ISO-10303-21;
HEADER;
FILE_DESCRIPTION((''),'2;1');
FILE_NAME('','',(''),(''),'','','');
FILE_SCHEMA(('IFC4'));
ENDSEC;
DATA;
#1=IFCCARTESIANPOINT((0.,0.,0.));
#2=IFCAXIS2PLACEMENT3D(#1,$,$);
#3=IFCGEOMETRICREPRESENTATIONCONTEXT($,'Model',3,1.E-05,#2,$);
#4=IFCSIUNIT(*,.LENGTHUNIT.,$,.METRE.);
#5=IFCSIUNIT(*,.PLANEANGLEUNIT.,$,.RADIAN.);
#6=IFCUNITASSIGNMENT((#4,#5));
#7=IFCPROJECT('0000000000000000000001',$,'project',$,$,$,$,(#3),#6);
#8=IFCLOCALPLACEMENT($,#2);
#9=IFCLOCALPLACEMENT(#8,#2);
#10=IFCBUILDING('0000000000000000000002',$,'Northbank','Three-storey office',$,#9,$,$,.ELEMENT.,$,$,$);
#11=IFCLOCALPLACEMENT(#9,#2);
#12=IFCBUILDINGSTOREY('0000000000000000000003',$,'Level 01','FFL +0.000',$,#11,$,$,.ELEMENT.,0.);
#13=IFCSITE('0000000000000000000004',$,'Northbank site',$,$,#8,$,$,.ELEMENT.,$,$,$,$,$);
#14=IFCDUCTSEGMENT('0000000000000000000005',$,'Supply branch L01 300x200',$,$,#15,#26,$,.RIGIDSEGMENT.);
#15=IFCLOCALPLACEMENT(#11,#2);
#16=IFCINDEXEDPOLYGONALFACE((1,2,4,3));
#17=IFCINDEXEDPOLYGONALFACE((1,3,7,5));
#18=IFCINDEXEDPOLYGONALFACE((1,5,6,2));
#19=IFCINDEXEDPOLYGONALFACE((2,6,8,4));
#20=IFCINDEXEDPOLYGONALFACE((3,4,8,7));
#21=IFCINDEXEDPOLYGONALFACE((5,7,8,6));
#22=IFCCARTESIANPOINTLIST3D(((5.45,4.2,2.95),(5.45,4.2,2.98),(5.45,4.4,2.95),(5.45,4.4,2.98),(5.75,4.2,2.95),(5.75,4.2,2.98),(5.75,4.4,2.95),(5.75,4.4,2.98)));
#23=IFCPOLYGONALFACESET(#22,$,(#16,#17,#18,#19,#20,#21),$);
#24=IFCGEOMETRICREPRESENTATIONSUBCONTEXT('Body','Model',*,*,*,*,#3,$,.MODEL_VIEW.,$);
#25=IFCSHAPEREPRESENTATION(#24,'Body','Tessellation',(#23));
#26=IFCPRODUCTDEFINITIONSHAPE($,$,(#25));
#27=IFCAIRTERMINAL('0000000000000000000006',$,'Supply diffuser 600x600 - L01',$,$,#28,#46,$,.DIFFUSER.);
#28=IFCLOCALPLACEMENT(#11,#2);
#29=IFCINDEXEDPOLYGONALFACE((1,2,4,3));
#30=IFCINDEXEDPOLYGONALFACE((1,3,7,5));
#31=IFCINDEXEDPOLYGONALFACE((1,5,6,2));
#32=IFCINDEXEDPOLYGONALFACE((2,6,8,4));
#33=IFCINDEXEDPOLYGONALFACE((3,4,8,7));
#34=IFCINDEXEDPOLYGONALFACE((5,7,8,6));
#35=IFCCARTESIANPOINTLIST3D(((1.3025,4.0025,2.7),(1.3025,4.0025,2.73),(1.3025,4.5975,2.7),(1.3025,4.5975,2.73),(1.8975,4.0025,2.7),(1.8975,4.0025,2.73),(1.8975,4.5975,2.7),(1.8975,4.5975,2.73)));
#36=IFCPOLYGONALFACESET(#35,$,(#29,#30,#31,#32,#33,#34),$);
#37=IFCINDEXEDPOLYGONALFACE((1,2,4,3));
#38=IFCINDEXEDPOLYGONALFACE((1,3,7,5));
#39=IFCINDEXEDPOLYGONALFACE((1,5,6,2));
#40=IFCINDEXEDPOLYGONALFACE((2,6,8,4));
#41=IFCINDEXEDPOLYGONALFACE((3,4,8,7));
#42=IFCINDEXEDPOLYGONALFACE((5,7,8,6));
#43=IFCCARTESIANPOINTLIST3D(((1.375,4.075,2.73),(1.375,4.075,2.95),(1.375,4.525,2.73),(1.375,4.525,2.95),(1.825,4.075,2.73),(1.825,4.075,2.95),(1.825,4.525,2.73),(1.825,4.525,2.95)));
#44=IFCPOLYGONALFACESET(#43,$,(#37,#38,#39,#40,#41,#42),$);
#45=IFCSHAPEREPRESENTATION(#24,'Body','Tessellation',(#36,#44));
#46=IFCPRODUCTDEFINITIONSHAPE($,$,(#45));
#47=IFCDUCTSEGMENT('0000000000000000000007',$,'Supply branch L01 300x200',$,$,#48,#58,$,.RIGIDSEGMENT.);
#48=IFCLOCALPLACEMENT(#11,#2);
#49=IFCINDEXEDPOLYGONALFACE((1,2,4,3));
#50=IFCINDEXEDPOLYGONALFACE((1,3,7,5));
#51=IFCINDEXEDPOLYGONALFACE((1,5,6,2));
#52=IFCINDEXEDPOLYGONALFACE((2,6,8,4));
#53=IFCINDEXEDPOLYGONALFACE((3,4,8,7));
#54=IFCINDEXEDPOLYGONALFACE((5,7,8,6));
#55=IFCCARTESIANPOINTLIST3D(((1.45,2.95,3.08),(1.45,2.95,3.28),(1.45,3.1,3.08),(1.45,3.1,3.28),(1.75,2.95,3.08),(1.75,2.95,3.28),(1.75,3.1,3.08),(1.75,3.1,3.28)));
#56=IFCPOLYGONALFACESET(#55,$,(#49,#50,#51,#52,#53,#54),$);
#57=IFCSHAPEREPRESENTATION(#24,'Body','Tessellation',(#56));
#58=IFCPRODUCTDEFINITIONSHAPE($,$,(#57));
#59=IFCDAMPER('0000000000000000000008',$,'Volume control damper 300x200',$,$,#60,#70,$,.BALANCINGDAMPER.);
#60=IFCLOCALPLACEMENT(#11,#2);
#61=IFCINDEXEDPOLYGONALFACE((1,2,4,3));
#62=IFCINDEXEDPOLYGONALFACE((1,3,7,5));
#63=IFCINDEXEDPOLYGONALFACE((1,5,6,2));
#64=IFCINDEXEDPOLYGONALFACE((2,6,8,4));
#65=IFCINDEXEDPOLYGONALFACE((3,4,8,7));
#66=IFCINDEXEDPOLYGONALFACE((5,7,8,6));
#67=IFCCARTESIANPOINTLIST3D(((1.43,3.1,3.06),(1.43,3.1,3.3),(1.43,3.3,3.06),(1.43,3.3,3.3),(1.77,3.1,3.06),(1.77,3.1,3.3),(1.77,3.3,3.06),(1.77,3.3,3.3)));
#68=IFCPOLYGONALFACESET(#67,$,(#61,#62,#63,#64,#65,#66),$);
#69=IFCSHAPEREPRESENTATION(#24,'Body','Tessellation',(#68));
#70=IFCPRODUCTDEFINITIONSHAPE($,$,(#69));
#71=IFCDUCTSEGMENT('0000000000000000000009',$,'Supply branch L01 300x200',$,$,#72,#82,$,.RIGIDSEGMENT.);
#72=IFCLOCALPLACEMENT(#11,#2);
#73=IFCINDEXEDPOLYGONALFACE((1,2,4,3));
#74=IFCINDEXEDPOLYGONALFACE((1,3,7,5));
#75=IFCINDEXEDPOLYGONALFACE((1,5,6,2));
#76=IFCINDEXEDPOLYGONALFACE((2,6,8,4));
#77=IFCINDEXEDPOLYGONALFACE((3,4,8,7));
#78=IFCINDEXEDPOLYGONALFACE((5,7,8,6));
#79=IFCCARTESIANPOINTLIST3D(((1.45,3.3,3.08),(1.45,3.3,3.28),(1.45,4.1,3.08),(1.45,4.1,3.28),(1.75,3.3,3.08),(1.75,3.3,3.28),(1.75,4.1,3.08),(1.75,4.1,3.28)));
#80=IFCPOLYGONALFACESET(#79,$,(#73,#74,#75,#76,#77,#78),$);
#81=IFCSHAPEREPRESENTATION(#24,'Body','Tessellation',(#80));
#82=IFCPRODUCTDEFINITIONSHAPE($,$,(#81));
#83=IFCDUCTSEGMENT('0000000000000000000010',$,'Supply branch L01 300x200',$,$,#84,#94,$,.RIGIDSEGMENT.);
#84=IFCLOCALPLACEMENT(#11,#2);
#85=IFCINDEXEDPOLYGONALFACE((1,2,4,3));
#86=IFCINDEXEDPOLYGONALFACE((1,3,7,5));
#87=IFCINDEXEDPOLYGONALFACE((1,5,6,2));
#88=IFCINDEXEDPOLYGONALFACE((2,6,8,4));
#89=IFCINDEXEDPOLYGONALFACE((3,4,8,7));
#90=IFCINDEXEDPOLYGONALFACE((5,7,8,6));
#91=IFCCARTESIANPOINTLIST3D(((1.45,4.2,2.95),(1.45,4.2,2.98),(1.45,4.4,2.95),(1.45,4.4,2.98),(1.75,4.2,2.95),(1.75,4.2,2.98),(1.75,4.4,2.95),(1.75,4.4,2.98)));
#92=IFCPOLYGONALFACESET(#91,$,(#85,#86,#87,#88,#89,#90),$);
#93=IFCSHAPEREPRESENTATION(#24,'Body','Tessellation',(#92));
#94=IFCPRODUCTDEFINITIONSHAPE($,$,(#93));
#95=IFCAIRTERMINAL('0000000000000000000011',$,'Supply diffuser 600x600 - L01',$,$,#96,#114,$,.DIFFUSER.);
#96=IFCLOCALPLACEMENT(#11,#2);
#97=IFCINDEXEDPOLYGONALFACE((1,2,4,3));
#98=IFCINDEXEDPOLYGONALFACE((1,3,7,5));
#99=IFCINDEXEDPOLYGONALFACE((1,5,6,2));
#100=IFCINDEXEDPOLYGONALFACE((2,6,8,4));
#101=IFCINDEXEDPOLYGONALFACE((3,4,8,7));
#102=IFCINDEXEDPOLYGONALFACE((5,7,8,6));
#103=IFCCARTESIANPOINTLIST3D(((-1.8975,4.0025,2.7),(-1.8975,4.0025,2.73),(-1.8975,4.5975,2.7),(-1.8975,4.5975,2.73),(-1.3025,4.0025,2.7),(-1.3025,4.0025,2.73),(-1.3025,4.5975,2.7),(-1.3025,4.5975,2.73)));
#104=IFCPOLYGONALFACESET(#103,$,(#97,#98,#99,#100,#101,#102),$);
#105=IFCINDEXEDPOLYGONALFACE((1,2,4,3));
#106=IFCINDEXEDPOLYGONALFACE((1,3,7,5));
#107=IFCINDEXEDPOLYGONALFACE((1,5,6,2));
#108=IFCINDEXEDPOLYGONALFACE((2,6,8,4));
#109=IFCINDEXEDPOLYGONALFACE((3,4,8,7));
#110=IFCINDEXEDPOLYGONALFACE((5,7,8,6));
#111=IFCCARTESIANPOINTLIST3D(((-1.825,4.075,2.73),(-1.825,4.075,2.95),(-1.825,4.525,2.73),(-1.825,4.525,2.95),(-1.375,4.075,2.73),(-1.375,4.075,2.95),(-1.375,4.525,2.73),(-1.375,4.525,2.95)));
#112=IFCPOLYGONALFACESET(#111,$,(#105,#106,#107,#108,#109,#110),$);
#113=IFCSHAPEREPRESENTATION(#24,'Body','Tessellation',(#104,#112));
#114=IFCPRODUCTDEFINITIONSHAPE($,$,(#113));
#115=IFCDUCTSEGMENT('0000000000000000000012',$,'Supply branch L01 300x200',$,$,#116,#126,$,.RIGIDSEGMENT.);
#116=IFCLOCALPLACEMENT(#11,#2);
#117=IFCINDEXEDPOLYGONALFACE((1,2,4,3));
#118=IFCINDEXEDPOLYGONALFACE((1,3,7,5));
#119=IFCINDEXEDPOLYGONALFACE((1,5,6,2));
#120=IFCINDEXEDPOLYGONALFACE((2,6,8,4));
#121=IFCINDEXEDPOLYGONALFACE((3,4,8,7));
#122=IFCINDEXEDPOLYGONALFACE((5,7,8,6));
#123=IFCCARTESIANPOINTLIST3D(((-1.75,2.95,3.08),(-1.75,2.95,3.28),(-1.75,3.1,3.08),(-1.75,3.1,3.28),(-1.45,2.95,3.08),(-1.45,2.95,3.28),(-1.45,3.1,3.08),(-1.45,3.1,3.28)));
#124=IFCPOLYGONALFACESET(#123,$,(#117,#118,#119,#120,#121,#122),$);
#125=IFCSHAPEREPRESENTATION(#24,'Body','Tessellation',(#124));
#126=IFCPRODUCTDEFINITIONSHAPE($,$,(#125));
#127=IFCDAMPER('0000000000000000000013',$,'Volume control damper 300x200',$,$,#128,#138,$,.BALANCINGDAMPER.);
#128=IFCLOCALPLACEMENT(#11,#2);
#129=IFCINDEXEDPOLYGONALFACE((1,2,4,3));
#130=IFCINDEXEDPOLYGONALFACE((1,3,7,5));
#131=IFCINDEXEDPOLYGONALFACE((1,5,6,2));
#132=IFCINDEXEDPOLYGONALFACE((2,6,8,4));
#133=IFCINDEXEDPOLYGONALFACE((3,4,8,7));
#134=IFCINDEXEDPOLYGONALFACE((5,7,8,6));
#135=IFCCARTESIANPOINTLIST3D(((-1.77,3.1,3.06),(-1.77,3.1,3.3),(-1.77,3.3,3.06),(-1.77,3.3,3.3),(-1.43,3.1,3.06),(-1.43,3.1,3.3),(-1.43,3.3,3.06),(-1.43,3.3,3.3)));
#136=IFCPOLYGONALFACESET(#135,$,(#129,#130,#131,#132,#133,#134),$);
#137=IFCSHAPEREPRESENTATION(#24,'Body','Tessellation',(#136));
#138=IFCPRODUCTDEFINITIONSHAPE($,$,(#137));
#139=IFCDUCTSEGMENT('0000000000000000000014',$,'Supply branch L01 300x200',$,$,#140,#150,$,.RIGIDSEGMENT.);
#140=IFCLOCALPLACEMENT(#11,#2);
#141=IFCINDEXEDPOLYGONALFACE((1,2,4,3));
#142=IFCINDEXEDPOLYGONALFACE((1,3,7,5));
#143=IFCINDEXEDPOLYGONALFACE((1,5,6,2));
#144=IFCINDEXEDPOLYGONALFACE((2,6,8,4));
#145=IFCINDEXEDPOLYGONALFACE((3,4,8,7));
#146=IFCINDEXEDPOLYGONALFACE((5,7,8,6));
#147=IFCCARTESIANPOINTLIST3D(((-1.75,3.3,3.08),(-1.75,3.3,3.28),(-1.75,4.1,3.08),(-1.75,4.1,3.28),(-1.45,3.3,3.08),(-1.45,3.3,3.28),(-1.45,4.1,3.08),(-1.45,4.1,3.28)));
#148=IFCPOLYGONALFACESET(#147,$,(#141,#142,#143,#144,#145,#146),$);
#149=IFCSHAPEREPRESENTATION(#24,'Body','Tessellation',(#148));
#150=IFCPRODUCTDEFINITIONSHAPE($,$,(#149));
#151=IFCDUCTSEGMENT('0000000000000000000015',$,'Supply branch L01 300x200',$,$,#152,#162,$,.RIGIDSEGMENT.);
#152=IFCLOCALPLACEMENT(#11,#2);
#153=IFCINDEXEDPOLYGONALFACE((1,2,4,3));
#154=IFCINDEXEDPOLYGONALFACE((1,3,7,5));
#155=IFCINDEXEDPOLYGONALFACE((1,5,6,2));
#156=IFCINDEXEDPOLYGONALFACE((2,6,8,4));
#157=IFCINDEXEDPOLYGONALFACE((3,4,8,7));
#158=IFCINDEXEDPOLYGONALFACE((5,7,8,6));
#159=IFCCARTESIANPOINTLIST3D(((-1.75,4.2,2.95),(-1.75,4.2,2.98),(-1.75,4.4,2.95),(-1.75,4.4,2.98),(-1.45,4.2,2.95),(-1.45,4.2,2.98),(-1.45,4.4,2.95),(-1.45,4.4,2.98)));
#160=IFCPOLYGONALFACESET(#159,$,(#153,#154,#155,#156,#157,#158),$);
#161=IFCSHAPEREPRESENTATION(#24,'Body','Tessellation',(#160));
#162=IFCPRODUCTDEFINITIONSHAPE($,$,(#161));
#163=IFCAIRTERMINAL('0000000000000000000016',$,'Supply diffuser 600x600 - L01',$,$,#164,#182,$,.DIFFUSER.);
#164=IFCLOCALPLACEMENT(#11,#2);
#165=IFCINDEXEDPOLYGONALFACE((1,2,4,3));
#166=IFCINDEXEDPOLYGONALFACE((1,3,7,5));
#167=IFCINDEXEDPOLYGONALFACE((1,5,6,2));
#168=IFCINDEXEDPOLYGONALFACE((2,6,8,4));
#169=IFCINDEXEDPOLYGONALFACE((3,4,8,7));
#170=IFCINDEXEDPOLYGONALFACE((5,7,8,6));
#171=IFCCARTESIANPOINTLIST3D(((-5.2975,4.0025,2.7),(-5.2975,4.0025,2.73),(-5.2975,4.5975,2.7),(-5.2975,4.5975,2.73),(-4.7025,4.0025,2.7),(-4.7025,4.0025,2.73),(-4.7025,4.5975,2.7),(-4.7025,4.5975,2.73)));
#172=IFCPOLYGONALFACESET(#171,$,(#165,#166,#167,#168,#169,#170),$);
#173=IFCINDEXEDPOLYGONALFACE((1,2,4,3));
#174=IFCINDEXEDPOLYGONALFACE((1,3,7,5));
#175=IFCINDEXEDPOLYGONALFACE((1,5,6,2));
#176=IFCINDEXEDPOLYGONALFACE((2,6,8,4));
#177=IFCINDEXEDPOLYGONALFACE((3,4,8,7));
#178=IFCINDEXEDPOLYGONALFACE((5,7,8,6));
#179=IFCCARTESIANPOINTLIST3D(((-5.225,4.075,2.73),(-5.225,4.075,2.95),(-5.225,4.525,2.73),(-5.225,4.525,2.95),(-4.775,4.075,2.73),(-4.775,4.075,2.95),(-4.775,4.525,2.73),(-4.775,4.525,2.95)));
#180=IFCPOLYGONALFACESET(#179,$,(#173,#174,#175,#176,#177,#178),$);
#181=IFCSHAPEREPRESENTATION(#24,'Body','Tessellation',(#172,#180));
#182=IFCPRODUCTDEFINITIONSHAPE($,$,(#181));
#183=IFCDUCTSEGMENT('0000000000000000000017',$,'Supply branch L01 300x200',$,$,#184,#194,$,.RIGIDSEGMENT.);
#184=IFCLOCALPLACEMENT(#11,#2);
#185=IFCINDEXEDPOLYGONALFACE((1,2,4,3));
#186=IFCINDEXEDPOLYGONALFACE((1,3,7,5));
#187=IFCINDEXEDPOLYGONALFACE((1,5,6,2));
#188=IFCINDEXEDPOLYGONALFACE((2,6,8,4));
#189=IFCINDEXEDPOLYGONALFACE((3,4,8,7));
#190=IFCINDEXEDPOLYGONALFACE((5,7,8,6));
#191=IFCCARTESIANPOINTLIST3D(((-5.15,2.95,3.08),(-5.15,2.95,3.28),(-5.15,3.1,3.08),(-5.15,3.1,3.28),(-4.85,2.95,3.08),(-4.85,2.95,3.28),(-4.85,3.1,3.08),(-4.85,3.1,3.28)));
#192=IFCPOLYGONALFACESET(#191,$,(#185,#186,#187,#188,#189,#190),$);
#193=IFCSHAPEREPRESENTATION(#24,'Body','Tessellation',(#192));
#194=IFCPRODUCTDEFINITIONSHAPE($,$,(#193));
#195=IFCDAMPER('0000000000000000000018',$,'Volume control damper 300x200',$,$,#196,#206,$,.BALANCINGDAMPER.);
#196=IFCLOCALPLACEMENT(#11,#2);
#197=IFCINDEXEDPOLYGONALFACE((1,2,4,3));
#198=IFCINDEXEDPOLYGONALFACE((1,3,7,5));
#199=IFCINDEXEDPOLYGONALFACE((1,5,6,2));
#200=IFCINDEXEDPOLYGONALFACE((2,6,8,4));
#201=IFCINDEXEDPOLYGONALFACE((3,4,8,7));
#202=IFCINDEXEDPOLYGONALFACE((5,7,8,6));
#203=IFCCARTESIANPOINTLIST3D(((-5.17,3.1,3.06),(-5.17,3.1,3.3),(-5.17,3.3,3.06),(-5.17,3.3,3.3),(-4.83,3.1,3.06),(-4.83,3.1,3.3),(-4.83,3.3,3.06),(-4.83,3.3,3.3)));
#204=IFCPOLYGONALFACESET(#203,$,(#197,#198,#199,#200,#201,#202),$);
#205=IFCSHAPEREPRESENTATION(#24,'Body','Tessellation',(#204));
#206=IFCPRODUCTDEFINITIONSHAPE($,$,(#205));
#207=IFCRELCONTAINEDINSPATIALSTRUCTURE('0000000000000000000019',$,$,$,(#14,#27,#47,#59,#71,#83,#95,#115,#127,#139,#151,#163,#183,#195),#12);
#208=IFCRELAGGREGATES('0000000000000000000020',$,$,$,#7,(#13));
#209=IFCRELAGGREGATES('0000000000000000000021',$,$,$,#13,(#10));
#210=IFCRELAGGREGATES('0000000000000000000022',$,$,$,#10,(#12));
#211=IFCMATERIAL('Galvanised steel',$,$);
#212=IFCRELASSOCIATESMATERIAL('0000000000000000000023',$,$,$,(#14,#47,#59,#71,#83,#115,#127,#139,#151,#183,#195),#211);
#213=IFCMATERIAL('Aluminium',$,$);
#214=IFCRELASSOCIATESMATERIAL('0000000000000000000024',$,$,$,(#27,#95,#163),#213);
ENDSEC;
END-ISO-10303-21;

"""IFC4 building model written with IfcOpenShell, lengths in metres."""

from ifc_helpers import new_model, si_unit, frame, origin, place, context, subcontext, project, spatial, rectangle, extrude, material, element, save


model = new_model("IFC4")

# Units and contexts
model_context = context("Model", 3, precision=1e-05, world=origin())
body_context = subcontext(model_context, "Body", "Model", "MODEL_VIEW")
ifc_project = project(units=[si_unit("LENGTHUNIT", "METRE"), si_unit("PLANEANGLEUNIT", "RADIAN")], contexts=[model_context])

# Site, building, storey
site_placement = place(None, origin())
site = spatial("IfcSite", under=ifc_project, at=site_placement, Name="Northbank site", CompositionType="ELEMENT")
building_placement = place(site_placement, origin())
building = spatial("IfcBuilding", under=site, at=building_placement, Name="Northbank", Description="Three-storey office", CompositionType="ELEMENT")
storey_placement = place(building_placement, origin())
storey = spatial("IfcBuildingStorey", under=building, at=storey_placement, Name="Level 01", Description="FFL +0.000", CompositionType="ELEMENT", Elevation=0.0)

# Duct segment
ifc_material_1 = material(Name="Galvanised steel")
duct_segment_1_placement = place(storey_placement, origin())
element("IfcDuctSegment", 1, at=duct_segment_1_placement, inside=storey, material=ifc_material_1, Name="Supply branch L01 300x200", PredefinedType="RIGIDSEGMENT", context=body_context, shape_type="SweptSolid", body=[
    extrude(rectangle(XDim=0.3, YDim=0.2), frame((5.6, 4.3, 2.98), z_axis=(0.0, 0.0, -1.0), x_axis=(-1.0, 0.0, 0.0)), (0.0, 0.0, 1.0), 0.03),
])

# Air terminal
ifc_material_2 = material(Name="Aluminium")
air_terminal_1_placement = place(storey_placement, origin())
element("IfcAirTerminal", 2, at=air_terminal_1_placement, inside=storey, material=ifc_material_2, Name="Supply diffuser 600x600 - L01", PredefinedType="DIFFUSER", context=body_context, shape_type="SweptSolid", body=[
    extrude(rectangle(XDim=0.595, YDim=0.595), frame((1.6, 4.3, 2.7)), (0.0, 0.0, 1.0), 0.03),
    extrude(rectangle(XDim=0.45, YDim=0.45), frame((1.6, 4.3, 2.73)), (0.0, 0.0, 1.0), 0.22),
])

# Duct segment
duct_segment_2_placement = place(storey_placement, origin())
element("IfcDuctSegment", 3, at=duct_segment_2_placement, inside=storey, material=ifc_material_1, Name="Supply branch L01 300x200", PredefinedType="RIGIDSEGMENT", context=body_context, shape_type="SweptSolid", body=[
    extrude(rectangle(XDim=0.3, YDim=0.2), frame((1.6, 2.95, 3.18), z_axis=(0.0, 1.0, 0.0), x_axis=(-1.0, 0.0, 0.0)), (0.0, 0.0, 1.0), 0.15),
])

# Damper
damper_1_placement = place(storey_placement, origin())
element("IfcDamper", 4, at=damper_1_placement, inside=storey, material=ifc_material_1, Name="Volume control damper 300x200", PredefinedType="BALANCINGDAMPER", context=body_context, shape_type="SweptSolid", body=[
    extrude(rectangle(XDim=0.34, YDim=0.24), frame((1.6, 3.1, 3.18), z_axis=(0.0, 1.0, 0.0), x_axis=(-1.0, 0.0, 0.0)), (0.0, 0.0, 1.0), 0.2),
])

# Duct segments
duct_segment_3_placement = place(storey_placement, origin())
element("IfcDuctSegment", 5, at=duct_segment_3_placement, inside=storey, material=ifc_material_1, Name="Supply branch L01 300x200", PredefinedType="RIGIDSEGMENT", context=body_context, shape_type="SweptSolid", body=[
    extrude(rectangle(XDim=0.3, YDim=0.2), frame((1.6, 3.3, 3.18), z_axis=(0.0, 1.0, 0.0), x_axis=(-1.0, 0.0, 0.0)), (0.0, 0.0, 1.0), 0.8),
])
duct_segment_4_placement = place(storey_placement, origin())
element("IfcDuctSegment", 6, at=duct_segment_4_placement, inside=storey, material=ifc_material_1, Name="Supply branch L01 300x200", PredefinedType="RIGIDSEGMENT", context=body_context, shape_type="SweptSolid", body=[
    extrude(rectangle(XDim=0.3, YDim=0.2), frame((1.6, 4.3, 2.98), z_axis=(0.0, 0.0, -1.0), x_axis=(-1.0, 0.0, 0.0)), (0.0, 0.0, 1.0), 0.03),
])

# Air terminal
air_terminal_2_placement = place(storey_placement, origin())
element("IfcAirTerminal", 7, at=air_terminal_2_placement, inside=storey, material=ifc_material_2, Name="Supply diffuser 600x600 - L01", PredefinedType="DIFFUSER", context=body_context, shape_type="SweptSolid", body=[
    extrude(rectangle(XDim=0.595, YDim=0.595), frame((-1.6, 4.3, 2.7)), (0.0, 0.0, 1.0), 0.03),
    extrude(rectangle(XDim=0.45, YDim=0.45), frame((-1.6, 4.3, 2.73)), (0.0, 0.0, 1.0), 0.22),
])

# Duct segment
duct_segment_5_placement = place(storey_placement, origin())
element("IfcDuctSegment", 8, at=duct_segment_5_placement, inside=storey, material=ifc_material_1, Name="Supply branch L01 300x200", PredefinedType="RIGIDSEGMENT", context=body_context, shape_type="SweptSolid", body=[
    extrude(rectangle(XDim=0.3, YDim=0.2), frame((-1.6, 2.95, 3.18), z_axis=(0.0, 1.0, 0.0), x_axis=(-1.0, 0.0, 0.0)), (0.0, 0.0, 1.0), 0.15),
])

# Damper
damper_2_placement = place(storey_placement, origin())
element("IfcDamper", 9, at=damper_2_placement, inside=storey, material=ifc_material_1, Name="Volume control damper 300x200", PredefinedType="BALANCINGDAMPER", context=body_context, shape_type="SweptSolid", body=[
    extrude(rectangle(XDim=0.34, YDim=0.24), frame((-1.6, 3.1, 3.18), z_axis=(0.0, 1.0, 0.0), x_axis=(-1.0, 0.0, 0.0)), (0.0, 0.0, 1.0), 0.2),
])

# Duct segments
duct_segment_6_placement = place(storey_placement, origin())
element("IfcDuctSegment", 10, at=duct_segment_6_placement, inside=storey, material=ifc_material_1, Name="Supply branch L01 300x200", PredefinedType="RIGIDSEGMENT", context=body_context, shape_type="SweptSolid", body=[
    extrude(rectangle(XDim=0.3, YDim=0.2), frame((-1.6, 3.3, 3.18), z_axis=(0.0, 1.0, 0.0), x_axis=(-1.0, 0.0, 0.0)), (0.0, 0.0, 1.0), 0.8),
])
duct_segment_7_placement = place(storey_placement, origin())
element("IfcDuctSegment", 11, at=duct_segment_7_placement, inside=storey, material=ifc_material_1, Name="Supply branch L01 300x200", PredefinedType="RIGIDSEGMENT", context=body_context, shape_type="SweptSolid", body=[
    extrude(rectangle(XDim=0.3, YDim=0.2), frame((-1.6, 4.3, 2.98), z_axis=(0.0, 0.0, -1.0), x_axis=(-1.0, 0.0, 0.0)), (0.0, 0.0, 1.0), 0.03),
])

# Air terminal
air_terminal_3_placement = place(storey_placement, origin())
element("IfcAirTerminal", 12, at=air_terminal_3_placement, inside=storey, material=ifc_material_2, Name="Supply diffuser 600x600 - L01", PredefinedType="DIFFUSER", context=body_context, shape_type="SweptSolid", body=[
    extrude(rectangle(XDim=0.595, YDim=0.595), frame((-5.0, 4.3, 2.7)), (0.0, 0.0, 1.0), 0.03),
    extrude(rectangle(XDim=0.45, YDim=0.45), frame((-5.0, 4.3, 2.73)), (0.0, 0.0, 1.0), 0.22),
])

# Duct segment
duct_segment_8_placement = place(storey_placement, origin())
element("IfcDuctSegment", 13, at=duct_segment_8_placement, inside=storey, material=ifc_material_1, Name="Supply branch L01 300x200", PredefinedType="RIGIDSEGMENT", context=body_context, shape_type="SweptSolid", body=[
    extrude(rectangle(XDim=0.3, YDim=0.2), frame((-5.0, 2.95, 3.18), z_axis=(0.0, 1.0, 0.0), x_axis=(-1.0, 0.0, 0.0)), (0.0, 0.0, 1.0), 0.15),
])

# Damper
damper_3_placement = place(storey_placement, origin())
element("IfcDamper", 14, at=damper_3_placement, inside=storey, material=ifc_material_1, Name="Volume control damper 300x200", PredefinedType="BALANCINGDAMPER", context=body_context, shape_type="SweptSolid", body=[
    extrude(rectangle(XDim=0.34, YDim=0.24), frame((-5.0, 3.1, 3.18), z_axis=(0.0, 1.0, 0.0), x_axis=(-1.0, 0.0, 0.0)), (0.0, 0.0, 1.0), 0.2),
])

save(model, "model.ifc")
